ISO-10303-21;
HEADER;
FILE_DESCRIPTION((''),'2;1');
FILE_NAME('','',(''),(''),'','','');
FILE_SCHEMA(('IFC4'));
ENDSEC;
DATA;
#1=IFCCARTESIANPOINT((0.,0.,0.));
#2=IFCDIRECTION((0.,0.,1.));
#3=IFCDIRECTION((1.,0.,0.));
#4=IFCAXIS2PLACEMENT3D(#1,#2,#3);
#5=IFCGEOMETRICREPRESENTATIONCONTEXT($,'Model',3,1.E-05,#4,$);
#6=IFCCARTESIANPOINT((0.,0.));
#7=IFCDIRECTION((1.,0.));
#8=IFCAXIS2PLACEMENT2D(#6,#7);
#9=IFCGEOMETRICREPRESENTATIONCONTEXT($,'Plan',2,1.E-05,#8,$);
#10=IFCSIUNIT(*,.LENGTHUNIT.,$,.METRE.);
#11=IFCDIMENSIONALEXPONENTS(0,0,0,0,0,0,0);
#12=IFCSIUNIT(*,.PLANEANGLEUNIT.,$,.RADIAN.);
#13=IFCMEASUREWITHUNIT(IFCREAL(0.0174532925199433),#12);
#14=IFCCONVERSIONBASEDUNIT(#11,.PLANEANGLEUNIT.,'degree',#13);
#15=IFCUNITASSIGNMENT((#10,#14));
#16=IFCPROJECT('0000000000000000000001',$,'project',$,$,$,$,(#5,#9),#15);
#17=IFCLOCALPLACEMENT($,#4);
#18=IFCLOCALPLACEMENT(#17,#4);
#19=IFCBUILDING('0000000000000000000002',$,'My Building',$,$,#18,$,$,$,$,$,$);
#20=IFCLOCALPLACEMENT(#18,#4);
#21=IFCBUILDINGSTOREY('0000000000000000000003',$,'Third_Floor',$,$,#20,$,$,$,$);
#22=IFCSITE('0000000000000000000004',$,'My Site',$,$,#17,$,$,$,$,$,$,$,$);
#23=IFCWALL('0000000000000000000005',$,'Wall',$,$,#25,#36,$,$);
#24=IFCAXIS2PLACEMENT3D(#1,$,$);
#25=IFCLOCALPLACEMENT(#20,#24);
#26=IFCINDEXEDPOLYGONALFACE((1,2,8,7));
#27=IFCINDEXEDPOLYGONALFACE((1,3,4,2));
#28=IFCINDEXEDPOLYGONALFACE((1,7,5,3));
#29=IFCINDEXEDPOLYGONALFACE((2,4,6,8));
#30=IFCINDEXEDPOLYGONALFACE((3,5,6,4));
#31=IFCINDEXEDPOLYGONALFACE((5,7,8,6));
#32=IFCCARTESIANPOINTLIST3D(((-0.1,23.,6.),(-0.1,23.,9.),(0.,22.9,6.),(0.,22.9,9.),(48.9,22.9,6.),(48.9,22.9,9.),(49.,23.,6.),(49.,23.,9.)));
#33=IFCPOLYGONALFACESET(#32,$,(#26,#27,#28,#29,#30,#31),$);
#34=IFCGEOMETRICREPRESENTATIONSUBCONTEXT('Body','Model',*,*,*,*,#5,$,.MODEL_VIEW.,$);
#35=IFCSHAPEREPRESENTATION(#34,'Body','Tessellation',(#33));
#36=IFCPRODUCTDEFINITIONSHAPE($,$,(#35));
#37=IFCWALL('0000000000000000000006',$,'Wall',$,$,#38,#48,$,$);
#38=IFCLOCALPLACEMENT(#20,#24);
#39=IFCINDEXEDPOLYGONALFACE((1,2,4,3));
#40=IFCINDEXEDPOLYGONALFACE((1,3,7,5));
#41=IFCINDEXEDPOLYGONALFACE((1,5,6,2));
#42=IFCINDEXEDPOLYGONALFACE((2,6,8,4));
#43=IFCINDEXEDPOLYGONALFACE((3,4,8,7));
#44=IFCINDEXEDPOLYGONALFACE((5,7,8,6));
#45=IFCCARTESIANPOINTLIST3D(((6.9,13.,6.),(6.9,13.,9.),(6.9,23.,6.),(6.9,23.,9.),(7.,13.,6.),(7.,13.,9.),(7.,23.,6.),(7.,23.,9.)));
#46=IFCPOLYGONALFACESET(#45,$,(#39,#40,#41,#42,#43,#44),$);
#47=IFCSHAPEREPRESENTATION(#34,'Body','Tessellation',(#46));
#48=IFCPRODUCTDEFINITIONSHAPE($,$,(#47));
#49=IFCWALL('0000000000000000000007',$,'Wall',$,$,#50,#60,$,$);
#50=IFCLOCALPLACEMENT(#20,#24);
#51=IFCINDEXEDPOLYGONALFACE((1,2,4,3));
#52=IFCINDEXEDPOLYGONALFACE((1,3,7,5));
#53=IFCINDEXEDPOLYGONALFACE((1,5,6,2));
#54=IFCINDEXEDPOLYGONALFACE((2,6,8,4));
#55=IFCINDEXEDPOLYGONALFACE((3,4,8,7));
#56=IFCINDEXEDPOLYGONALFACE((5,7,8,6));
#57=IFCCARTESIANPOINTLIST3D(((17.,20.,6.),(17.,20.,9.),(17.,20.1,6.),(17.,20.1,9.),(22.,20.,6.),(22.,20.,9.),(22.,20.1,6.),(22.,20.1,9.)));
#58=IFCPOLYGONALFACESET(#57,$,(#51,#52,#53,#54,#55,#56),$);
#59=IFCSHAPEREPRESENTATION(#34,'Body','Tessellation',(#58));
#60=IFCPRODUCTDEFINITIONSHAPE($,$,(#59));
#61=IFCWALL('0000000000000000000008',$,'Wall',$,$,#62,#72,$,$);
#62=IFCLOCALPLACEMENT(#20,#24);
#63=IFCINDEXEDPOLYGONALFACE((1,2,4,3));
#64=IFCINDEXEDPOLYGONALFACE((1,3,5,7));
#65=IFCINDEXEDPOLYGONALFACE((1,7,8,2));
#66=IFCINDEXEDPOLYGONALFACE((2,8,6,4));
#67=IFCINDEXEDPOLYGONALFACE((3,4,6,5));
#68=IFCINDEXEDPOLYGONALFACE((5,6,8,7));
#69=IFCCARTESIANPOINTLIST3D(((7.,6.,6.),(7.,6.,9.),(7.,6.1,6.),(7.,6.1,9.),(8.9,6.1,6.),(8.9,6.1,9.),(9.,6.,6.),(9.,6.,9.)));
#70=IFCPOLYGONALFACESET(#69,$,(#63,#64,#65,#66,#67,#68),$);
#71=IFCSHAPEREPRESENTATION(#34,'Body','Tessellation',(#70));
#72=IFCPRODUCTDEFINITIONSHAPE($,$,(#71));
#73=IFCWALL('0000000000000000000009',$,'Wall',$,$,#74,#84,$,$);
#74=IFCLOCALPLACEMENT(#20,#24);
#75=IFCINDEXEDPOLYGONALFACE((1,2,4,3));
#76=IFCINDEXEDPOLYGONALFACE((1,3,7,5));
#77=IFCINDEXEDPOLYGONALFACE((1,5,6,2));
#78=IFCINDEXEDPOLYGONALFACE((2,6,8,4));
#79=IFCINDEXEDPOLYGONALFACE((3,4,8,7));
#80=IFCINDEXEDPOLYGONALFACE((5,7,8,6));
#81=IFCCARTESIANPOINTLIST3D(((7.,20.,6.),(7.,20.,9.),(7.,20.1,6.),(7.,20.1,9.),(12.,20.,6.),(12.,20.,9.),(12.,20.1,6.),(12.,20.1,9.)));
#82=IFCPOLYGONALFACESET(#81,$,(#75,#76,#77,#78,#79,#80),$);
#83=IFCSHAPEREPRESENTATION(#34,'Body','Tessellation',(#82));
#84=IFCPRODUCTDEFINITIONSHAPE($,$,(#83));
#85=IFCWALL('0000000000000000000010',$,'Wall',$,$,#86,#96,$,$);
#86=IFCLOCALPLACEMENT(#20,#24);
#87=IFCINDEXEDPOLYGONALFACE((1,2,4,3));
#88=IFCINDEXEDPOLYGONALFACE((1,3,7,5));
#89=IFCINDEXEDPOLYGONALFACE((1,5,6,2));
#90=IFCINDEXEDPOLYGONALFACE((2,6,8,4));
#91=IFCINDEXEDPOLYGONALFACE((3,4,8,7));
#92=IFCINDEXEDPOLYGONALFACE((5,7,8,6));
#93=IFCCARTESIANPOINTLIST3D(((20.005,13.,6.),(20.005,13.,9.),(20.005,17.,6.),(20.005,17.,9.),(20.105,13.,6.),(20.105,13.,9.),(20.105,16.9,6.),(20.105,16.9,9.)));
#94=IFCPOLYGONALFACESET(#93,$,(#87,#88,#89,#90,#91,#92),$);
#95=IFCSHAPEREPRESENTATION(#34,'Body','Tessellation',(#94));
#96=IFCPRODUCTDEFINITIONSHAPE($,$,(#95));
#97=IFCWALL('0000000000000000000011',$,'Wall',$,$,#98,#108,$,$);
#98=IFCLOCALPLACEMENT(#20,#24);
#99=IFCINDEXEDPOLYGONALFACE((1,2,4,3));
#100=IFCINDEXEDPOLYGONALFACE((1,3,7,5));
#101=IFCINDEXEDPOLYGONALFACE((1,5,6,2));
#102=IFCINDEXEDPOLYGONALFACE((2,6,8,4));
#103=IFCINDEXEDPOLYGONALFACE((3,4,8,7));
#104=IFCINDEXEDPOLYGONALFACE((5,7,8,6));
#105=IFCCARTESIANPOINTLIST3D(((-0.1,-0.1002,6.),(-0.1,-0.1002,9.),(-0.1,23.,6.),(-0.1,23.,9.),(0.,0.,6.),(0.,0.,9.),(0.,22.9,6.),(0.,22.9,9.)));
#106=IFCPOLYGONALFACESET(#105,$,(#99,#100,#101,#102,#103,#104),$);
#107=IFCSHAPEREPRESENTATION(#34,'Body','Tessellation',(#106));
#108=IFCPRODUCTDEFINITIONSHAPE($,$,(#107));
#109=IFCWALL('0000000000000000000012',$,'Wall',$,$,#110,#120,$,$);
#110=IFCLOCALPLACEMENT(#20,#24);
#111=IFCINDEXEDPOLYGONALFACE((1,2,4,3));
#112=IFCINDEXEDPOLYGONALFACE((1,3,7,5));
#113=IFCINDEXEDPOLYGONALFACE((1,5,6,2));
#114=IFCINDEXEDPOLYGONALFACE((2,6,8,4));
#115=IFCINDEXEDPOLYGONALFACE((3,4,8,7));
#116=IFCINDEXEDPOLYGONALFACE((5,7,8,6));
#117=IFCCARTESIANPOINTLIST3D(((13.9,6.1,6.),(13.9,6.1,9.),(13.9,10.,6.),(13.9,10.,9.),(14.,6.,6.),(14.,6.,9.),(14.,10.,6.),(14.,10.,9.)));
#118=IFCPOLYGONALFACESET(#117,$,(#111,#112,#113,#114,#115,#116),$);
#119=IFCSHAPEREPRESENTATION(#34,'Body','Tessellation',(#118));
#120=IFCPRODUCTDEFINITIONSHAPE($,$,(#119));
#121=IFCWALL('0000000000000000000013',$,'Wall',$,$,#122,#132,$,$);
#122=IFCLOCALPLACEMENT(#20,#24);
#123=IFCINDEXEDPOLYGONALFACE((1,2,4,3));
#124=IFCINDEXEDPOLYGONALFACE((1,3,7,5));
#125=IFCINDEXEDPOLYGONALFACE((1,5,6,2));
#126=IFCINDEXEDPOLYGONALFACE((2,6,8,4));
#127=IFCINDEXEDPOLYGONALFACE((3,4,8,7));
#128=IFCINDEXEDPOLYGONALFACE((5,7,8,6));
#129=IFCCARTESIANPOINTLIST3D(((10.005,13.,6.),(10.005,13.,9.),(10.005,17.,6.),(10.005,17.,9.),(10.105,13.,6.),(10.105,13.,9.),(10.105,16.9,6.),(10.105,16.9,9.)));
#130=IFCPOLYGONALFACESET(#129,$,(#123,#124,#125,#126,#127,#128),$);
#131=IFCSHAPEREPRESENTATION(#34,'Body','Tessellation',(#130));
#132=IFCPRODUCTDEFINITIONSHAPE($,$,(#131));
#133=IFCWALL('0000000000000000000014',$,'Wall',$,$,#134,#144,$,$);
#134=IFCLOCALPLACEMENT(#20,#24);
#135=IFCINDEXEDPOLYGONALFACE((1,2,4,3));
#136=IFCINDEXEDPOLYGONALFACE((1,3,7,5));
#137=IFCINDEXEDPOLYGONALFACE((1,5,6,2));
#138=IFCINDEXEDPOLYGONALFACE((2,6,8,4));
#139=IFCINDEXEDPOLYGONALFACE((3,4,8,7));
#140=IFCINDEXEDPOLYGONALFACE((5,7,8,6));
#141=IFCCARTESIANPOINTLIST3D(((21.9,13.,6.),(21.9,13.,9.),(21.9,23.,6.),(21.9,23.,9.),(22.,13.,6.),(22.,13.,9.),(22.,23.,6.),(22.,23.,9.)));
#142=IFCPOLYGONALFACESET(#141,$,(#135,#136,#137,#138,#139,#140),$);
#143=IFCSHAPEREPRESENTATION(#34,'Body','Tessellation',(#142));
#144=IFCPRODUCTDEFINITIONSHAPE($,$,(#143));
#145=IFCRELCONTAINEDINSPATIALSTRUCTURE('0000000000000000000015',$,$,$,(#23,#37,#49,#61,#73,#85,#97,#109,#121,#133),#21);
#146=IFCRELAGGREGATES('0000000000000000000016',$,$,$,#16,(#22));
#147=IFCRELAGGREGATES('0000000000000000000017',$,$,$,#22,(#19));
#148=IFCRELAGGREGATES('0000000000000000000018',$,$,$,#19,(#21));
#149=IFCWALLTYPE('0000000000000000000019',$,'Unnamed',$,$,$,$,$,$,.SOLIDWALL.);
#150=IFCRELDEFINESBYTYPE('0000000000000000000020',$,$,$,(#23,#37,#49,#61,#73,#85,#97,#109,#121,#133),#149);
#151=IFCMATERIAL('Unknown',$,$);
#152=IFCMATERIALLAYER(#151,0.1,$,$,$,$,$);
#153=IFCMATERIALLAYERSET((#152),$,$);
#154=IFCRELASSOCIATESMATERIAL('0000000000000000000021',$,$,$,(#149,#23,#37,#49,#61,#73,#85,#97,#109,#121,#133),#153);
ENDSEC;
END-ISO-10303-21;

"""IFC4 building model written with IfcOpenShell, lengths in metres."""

from ifc_helpers import new_model, entity, si_unit, converted_unit, frame, origin_with_axes, origin_2d_with_axis, place, context, subcontext, project, spatial, line, indexed_curve, outline, extrude, material, layer, layer_set, layer_usage, type_object, element, save


model = new_model("IFC4")

# Units and contexts
model_context = context("Model", 3, precision=1e-05, world=origin_with_axes())
plan_context = context("Plan", 2, precision=1e-05, world=origin_2d_with_axis())
body_context = subcontext(model_context, "Body", "Model", "MODEL_VIEW")
ifc_project = project(units=[si_unit("LENGTHUNIT", "METRE"), converted_unit("PLANEANGLEUNIT", "degree", entity("IfcReal", 0.0174532925199433), si_unit("PLANEANGLEUNIT", "RADIAN"), dimensions=[0, 0, 0, 0, 0, 0, 0])], contexts=[model_context, plan_context])

# Site, building, storey
site_placement = place(None, origin_with_axes())
site = spatial("IfcSite", under=ifc_project, at=site_placement, Name="My Site")
building_placement = place(site_placement, origin_with_axes())
building = spatial("IfcBuilding", under=site, at=building_placement, Name="My Building")
storey_placement = place(building_placement, origin_with_axes())
storey = spatial("IfcBuildingStorey", under=building, at=storey_placement, Name="Third_Floor")

# Shared definitions
ifc_material = material(Name="Unknown")

# Walls
ifc_layer_1 = layer(ifc_material, 0.1)
ifc_layer_set_1 = layer_set([ifc_layer_1])
wall_type = type_object("IfcWallType", Name="Unnamed", PredefinedType="SOLIDWALL", material=ifc_layer_set_1)
ifc_layer_usage_1 = layer_usage(ifc_layer_set_1, "AXIS2", "POSITIVE", 0.0)
wall_1_placement = place(storey_placement, frame((0.0, 22.9, 6.0), z_axis=(0.0, 0.0, 1.0), x_axis=(1.0, 0.0, 0.0)))
element("IfcWall", 1, at=wall_1_placement, inside=storey, type_object=wall_type, material=ifc_layer_usage_1, Name="Wall", context=body_context, shape_type="SweptSolid", body=[
    extrude(outline(indexed_curve([(0.0, 0.0), (-0.1, 0.1), (49.0, 0.1), (48.9, 0.0)], segments=[line(1, 2, 3, 4, 1)])), origin_with_axes(), (0.0, 0.0, 1.0), 3.0),
])
ifc_layer_usage_2 = layer_usage(ifc_layer_set_1, "AXIS2", "POSITIVE", 0.0)
wall_2_placement = place(storey_placement, frame((6.9, 23.0, 6.0), z_axis=(0.0, 0.0, 1.0), x_axis=(0.0, -1.0, 0.0)))
element("IfcWall", 2, at=wall_2_placement, inside=storey, type_object=wall_type, material=ifc_layer_usage_2, Name="Wall", context=body_context, shape_type="SweptSolid", body=[
    extrude(outline(indexed_curve([(0.0, 0.0), (0.0, 0.1), (10.0, 0.1), (10.0, 0.0)], segments=[line(1, 2, 3, 4, 1)])), origin_with_axes(), (0.0, 0.0, 1.0), 3.0),
])
ifc_layer_usage_3 = layer_usage(ifc_layer_set_1, "AXIS2", "POSITIVE", 0.0)
wall_3_placement = place(storey_placement, frame((17.0, 20.0, 6.0), z_axis=(0.0, 0.0, 1.0), x_axis=(1.0, 0.0, 0.0)))
element("IfcWall", 3, at=wall_3_placement, inside=storey, type_object=wall_type, material=ifc_layer_usage_3, Name="Wall", context=body_context, shape_type="SweptSolid", body=[
    extrude(outline(indexed_curve([(0.0, 0.0), (0.0, 0.1), (5.0, 0.1), (5.0, 0.0)], segments=[line(1, 2, 3, 4, 1)])), origin_with_axes(), (0.0, 0.0, 1.0), 3.0),
])
ifc_layer_usage_4 = layer_usage(ifc_layer_set_1, "AXIS2", "POSITIVE", 0.0)
wall_4_placement = place(storey_placement, frame((7.0, 6.0, 6.0), z_axis=(0.0, 0.0, 1.0), x_axis=(1.0, 0.0, 0.0)))
element("IfcWall", 4, at=wall_4_placement, inside=storey, type_object=wall_type, material=ifc_layer_usage_4, Name="Wall", context=body_context, shape_type="SweptSolid", body=[
    extrude(outline(indexed_curve([(0.0, 0.0), (0.0, 0.1), (1.9, 0.1), (2.0, 0.0)], segments=[line(1, 2, 3, 4, 1)])), origin_with_axes(), (0.0, 0.0, 1.0), 3.0),
])
ifc_layer_usage_5 = layer_usage(ifc_layer_set_1, "AXIS2", "POSITIVE", 0.0)
wall_5_placement = place(storey_placement, frame((7.0, 20.0, 6.0), z_axis=(0.0, 0.0, 1.0), x_axis=(1.0, 0.0, 0.0)))
element("IfcWall", 5, at=wall_5_placement, inside=storey, type_object=wall_type, material=ifc_layer_usage_5, Name="Wall", context=body_context, shape_type="SweptSolid", body=[
    extrude(outline(indexed_curve([(0.0, 0.0), (0.0, 0.1), (5.0, 0.1), (5.0, 0.0)], segments=[line(1, 2, 3, 4, 1)])), origin_with_axes(), (0.0, 0.0, 1.0), 3.0),
])
ifc_layer_usage_6 = layer_usage(ifc_layer_set_1, "AXIS2", "POSITIVE", 0.0)
wall_6_placement = place(storey_placement, frame((20.005, 17.0, 6.0), z_axis=(0.0, 0.0, 1.0), x_axis=(0.0, -1.0, 0.0)))
element("IfcWall", 6, at=wall_6_placement, inside=storey, type_object=wall_type, material=ifc_layer_usage_6, Name="Wall", context=body_context, shape_type="SweptSolid", body=[
    extrude(outline(indexed_curve([(0.0, 0.0), (0.1, 0.1), (4.0, 0.1), (4.0, 0.0)], segments=[line(1, 2, 3, 4, 1)])), origin_with_axes(), (0.0, 0.0, 1.0), 3.0),
])
ifc_layer_usage_7 = layer_usage(ifc_layer_set_1, "AXIS2", "POSITIVE", 0.0)
wall_7_placement = place(storey_placement, frame((0.0, 0.0, 6.0), z_axis=(0.0, 0.0, 1.0), x_axis=(0.0, 1.0, 0.0)))
element("IfcWall", 7, at=wall_7_placement, inside=storey, type_object=wall_type, material=ifc_layer_usage_7, Name="Wall", context=body_context, shape_type="SweptSolid", body=[
    extrude(outline(indexed_curve([(0.0, 0.0), (-0.1002, 0.1), (23.0, 0.1), (22.9, 0.0)], segments=[line(1, 2, 3, 4, 1)])), origin_with_axes(), (0.0, 0.0, 1.0), 3.0),
])
ifc_layer_usage_8 = layer_usage(ifc_layer_set_1, "AXIS2", "POSITIVE", 0.0)
wall_8_placement = place(storey_placement, frame((14.0, 6.0, 6.0), z_axis=(0.0, 0.0, 1.0), x_axis=(0.0, 1.0, 0.0)))
element("IfcWall", 8, at=wall_8_placement, inside=storey, type_object=wall_type, material=ifc_layer_usage_8, Name="Wall", context=body_context, shape_type="SweptSolid", body=[
    extrude(outline(indexed_curve([(0.0, 0.0), (0.1, 0.1), (4.0, 0.1), (4.0, 0.0)], segments=[line(1, 2, 3, 4, 1)])), origin_with_axes(), (0.0, 0.0, 1.0), 3.0),
])
ifc_layer_usage_9 = layer_usage(ifc_layer_set_1, "AXIS2", "POSITIVE", 0.0)
wall_9_placement = place(storey_placement, frame((10.005, 17.0, 6.0), z_axis=(0.0, 0.0, 1.0), x_axis=(0.0, -1.0, 0.0)))
element("IfcWall", 9, at=wall_9_placement, inside=storey, type_object=wall_type, material=ifc_layer_usage_9, Name="Wall", context=body_context, shape_type="SweptSolid", body=[
    extrude(outline(indexed_curve([(0.0, 0.0), (0.1, 0.1), (4.0, 0.1), (4.0, 0.0)], segments=[line(1, 2, 3, 4, 1)])), origin_with_axes(), (0.0, 0.0, 1.0), 3.0),
])
ifc_layer_usage_10 = layer_usage(ifc_layer_set_1, "AXIS2", "POSITIVE", 0.0)
wall_10_placement = place(storey_placement, frame((21.9, 23.0, 6.0), z_axis=(0.0, 0.0, 1.0), x_axis=(0.0, -1.0, 0.0)))
element("IfcWall", 10, at=wall_10_placement, inside=storey, type_object=wall_type, material=ifc_layer_usage_10, Name="Wall", context=body_context, shape_type="SweptSolid", body=[
    extrude(outline(indexed_curve([(0.0, 0.0), (0.0, 0.1), (10.0, 0.1), (10.0, 0.0)], segments=[line(1, 2, 3, 4, 1)])), origin_with_axes(), (0.0, 0.0, 1.0), 3.0),
])

save(model, "model.ifc")
